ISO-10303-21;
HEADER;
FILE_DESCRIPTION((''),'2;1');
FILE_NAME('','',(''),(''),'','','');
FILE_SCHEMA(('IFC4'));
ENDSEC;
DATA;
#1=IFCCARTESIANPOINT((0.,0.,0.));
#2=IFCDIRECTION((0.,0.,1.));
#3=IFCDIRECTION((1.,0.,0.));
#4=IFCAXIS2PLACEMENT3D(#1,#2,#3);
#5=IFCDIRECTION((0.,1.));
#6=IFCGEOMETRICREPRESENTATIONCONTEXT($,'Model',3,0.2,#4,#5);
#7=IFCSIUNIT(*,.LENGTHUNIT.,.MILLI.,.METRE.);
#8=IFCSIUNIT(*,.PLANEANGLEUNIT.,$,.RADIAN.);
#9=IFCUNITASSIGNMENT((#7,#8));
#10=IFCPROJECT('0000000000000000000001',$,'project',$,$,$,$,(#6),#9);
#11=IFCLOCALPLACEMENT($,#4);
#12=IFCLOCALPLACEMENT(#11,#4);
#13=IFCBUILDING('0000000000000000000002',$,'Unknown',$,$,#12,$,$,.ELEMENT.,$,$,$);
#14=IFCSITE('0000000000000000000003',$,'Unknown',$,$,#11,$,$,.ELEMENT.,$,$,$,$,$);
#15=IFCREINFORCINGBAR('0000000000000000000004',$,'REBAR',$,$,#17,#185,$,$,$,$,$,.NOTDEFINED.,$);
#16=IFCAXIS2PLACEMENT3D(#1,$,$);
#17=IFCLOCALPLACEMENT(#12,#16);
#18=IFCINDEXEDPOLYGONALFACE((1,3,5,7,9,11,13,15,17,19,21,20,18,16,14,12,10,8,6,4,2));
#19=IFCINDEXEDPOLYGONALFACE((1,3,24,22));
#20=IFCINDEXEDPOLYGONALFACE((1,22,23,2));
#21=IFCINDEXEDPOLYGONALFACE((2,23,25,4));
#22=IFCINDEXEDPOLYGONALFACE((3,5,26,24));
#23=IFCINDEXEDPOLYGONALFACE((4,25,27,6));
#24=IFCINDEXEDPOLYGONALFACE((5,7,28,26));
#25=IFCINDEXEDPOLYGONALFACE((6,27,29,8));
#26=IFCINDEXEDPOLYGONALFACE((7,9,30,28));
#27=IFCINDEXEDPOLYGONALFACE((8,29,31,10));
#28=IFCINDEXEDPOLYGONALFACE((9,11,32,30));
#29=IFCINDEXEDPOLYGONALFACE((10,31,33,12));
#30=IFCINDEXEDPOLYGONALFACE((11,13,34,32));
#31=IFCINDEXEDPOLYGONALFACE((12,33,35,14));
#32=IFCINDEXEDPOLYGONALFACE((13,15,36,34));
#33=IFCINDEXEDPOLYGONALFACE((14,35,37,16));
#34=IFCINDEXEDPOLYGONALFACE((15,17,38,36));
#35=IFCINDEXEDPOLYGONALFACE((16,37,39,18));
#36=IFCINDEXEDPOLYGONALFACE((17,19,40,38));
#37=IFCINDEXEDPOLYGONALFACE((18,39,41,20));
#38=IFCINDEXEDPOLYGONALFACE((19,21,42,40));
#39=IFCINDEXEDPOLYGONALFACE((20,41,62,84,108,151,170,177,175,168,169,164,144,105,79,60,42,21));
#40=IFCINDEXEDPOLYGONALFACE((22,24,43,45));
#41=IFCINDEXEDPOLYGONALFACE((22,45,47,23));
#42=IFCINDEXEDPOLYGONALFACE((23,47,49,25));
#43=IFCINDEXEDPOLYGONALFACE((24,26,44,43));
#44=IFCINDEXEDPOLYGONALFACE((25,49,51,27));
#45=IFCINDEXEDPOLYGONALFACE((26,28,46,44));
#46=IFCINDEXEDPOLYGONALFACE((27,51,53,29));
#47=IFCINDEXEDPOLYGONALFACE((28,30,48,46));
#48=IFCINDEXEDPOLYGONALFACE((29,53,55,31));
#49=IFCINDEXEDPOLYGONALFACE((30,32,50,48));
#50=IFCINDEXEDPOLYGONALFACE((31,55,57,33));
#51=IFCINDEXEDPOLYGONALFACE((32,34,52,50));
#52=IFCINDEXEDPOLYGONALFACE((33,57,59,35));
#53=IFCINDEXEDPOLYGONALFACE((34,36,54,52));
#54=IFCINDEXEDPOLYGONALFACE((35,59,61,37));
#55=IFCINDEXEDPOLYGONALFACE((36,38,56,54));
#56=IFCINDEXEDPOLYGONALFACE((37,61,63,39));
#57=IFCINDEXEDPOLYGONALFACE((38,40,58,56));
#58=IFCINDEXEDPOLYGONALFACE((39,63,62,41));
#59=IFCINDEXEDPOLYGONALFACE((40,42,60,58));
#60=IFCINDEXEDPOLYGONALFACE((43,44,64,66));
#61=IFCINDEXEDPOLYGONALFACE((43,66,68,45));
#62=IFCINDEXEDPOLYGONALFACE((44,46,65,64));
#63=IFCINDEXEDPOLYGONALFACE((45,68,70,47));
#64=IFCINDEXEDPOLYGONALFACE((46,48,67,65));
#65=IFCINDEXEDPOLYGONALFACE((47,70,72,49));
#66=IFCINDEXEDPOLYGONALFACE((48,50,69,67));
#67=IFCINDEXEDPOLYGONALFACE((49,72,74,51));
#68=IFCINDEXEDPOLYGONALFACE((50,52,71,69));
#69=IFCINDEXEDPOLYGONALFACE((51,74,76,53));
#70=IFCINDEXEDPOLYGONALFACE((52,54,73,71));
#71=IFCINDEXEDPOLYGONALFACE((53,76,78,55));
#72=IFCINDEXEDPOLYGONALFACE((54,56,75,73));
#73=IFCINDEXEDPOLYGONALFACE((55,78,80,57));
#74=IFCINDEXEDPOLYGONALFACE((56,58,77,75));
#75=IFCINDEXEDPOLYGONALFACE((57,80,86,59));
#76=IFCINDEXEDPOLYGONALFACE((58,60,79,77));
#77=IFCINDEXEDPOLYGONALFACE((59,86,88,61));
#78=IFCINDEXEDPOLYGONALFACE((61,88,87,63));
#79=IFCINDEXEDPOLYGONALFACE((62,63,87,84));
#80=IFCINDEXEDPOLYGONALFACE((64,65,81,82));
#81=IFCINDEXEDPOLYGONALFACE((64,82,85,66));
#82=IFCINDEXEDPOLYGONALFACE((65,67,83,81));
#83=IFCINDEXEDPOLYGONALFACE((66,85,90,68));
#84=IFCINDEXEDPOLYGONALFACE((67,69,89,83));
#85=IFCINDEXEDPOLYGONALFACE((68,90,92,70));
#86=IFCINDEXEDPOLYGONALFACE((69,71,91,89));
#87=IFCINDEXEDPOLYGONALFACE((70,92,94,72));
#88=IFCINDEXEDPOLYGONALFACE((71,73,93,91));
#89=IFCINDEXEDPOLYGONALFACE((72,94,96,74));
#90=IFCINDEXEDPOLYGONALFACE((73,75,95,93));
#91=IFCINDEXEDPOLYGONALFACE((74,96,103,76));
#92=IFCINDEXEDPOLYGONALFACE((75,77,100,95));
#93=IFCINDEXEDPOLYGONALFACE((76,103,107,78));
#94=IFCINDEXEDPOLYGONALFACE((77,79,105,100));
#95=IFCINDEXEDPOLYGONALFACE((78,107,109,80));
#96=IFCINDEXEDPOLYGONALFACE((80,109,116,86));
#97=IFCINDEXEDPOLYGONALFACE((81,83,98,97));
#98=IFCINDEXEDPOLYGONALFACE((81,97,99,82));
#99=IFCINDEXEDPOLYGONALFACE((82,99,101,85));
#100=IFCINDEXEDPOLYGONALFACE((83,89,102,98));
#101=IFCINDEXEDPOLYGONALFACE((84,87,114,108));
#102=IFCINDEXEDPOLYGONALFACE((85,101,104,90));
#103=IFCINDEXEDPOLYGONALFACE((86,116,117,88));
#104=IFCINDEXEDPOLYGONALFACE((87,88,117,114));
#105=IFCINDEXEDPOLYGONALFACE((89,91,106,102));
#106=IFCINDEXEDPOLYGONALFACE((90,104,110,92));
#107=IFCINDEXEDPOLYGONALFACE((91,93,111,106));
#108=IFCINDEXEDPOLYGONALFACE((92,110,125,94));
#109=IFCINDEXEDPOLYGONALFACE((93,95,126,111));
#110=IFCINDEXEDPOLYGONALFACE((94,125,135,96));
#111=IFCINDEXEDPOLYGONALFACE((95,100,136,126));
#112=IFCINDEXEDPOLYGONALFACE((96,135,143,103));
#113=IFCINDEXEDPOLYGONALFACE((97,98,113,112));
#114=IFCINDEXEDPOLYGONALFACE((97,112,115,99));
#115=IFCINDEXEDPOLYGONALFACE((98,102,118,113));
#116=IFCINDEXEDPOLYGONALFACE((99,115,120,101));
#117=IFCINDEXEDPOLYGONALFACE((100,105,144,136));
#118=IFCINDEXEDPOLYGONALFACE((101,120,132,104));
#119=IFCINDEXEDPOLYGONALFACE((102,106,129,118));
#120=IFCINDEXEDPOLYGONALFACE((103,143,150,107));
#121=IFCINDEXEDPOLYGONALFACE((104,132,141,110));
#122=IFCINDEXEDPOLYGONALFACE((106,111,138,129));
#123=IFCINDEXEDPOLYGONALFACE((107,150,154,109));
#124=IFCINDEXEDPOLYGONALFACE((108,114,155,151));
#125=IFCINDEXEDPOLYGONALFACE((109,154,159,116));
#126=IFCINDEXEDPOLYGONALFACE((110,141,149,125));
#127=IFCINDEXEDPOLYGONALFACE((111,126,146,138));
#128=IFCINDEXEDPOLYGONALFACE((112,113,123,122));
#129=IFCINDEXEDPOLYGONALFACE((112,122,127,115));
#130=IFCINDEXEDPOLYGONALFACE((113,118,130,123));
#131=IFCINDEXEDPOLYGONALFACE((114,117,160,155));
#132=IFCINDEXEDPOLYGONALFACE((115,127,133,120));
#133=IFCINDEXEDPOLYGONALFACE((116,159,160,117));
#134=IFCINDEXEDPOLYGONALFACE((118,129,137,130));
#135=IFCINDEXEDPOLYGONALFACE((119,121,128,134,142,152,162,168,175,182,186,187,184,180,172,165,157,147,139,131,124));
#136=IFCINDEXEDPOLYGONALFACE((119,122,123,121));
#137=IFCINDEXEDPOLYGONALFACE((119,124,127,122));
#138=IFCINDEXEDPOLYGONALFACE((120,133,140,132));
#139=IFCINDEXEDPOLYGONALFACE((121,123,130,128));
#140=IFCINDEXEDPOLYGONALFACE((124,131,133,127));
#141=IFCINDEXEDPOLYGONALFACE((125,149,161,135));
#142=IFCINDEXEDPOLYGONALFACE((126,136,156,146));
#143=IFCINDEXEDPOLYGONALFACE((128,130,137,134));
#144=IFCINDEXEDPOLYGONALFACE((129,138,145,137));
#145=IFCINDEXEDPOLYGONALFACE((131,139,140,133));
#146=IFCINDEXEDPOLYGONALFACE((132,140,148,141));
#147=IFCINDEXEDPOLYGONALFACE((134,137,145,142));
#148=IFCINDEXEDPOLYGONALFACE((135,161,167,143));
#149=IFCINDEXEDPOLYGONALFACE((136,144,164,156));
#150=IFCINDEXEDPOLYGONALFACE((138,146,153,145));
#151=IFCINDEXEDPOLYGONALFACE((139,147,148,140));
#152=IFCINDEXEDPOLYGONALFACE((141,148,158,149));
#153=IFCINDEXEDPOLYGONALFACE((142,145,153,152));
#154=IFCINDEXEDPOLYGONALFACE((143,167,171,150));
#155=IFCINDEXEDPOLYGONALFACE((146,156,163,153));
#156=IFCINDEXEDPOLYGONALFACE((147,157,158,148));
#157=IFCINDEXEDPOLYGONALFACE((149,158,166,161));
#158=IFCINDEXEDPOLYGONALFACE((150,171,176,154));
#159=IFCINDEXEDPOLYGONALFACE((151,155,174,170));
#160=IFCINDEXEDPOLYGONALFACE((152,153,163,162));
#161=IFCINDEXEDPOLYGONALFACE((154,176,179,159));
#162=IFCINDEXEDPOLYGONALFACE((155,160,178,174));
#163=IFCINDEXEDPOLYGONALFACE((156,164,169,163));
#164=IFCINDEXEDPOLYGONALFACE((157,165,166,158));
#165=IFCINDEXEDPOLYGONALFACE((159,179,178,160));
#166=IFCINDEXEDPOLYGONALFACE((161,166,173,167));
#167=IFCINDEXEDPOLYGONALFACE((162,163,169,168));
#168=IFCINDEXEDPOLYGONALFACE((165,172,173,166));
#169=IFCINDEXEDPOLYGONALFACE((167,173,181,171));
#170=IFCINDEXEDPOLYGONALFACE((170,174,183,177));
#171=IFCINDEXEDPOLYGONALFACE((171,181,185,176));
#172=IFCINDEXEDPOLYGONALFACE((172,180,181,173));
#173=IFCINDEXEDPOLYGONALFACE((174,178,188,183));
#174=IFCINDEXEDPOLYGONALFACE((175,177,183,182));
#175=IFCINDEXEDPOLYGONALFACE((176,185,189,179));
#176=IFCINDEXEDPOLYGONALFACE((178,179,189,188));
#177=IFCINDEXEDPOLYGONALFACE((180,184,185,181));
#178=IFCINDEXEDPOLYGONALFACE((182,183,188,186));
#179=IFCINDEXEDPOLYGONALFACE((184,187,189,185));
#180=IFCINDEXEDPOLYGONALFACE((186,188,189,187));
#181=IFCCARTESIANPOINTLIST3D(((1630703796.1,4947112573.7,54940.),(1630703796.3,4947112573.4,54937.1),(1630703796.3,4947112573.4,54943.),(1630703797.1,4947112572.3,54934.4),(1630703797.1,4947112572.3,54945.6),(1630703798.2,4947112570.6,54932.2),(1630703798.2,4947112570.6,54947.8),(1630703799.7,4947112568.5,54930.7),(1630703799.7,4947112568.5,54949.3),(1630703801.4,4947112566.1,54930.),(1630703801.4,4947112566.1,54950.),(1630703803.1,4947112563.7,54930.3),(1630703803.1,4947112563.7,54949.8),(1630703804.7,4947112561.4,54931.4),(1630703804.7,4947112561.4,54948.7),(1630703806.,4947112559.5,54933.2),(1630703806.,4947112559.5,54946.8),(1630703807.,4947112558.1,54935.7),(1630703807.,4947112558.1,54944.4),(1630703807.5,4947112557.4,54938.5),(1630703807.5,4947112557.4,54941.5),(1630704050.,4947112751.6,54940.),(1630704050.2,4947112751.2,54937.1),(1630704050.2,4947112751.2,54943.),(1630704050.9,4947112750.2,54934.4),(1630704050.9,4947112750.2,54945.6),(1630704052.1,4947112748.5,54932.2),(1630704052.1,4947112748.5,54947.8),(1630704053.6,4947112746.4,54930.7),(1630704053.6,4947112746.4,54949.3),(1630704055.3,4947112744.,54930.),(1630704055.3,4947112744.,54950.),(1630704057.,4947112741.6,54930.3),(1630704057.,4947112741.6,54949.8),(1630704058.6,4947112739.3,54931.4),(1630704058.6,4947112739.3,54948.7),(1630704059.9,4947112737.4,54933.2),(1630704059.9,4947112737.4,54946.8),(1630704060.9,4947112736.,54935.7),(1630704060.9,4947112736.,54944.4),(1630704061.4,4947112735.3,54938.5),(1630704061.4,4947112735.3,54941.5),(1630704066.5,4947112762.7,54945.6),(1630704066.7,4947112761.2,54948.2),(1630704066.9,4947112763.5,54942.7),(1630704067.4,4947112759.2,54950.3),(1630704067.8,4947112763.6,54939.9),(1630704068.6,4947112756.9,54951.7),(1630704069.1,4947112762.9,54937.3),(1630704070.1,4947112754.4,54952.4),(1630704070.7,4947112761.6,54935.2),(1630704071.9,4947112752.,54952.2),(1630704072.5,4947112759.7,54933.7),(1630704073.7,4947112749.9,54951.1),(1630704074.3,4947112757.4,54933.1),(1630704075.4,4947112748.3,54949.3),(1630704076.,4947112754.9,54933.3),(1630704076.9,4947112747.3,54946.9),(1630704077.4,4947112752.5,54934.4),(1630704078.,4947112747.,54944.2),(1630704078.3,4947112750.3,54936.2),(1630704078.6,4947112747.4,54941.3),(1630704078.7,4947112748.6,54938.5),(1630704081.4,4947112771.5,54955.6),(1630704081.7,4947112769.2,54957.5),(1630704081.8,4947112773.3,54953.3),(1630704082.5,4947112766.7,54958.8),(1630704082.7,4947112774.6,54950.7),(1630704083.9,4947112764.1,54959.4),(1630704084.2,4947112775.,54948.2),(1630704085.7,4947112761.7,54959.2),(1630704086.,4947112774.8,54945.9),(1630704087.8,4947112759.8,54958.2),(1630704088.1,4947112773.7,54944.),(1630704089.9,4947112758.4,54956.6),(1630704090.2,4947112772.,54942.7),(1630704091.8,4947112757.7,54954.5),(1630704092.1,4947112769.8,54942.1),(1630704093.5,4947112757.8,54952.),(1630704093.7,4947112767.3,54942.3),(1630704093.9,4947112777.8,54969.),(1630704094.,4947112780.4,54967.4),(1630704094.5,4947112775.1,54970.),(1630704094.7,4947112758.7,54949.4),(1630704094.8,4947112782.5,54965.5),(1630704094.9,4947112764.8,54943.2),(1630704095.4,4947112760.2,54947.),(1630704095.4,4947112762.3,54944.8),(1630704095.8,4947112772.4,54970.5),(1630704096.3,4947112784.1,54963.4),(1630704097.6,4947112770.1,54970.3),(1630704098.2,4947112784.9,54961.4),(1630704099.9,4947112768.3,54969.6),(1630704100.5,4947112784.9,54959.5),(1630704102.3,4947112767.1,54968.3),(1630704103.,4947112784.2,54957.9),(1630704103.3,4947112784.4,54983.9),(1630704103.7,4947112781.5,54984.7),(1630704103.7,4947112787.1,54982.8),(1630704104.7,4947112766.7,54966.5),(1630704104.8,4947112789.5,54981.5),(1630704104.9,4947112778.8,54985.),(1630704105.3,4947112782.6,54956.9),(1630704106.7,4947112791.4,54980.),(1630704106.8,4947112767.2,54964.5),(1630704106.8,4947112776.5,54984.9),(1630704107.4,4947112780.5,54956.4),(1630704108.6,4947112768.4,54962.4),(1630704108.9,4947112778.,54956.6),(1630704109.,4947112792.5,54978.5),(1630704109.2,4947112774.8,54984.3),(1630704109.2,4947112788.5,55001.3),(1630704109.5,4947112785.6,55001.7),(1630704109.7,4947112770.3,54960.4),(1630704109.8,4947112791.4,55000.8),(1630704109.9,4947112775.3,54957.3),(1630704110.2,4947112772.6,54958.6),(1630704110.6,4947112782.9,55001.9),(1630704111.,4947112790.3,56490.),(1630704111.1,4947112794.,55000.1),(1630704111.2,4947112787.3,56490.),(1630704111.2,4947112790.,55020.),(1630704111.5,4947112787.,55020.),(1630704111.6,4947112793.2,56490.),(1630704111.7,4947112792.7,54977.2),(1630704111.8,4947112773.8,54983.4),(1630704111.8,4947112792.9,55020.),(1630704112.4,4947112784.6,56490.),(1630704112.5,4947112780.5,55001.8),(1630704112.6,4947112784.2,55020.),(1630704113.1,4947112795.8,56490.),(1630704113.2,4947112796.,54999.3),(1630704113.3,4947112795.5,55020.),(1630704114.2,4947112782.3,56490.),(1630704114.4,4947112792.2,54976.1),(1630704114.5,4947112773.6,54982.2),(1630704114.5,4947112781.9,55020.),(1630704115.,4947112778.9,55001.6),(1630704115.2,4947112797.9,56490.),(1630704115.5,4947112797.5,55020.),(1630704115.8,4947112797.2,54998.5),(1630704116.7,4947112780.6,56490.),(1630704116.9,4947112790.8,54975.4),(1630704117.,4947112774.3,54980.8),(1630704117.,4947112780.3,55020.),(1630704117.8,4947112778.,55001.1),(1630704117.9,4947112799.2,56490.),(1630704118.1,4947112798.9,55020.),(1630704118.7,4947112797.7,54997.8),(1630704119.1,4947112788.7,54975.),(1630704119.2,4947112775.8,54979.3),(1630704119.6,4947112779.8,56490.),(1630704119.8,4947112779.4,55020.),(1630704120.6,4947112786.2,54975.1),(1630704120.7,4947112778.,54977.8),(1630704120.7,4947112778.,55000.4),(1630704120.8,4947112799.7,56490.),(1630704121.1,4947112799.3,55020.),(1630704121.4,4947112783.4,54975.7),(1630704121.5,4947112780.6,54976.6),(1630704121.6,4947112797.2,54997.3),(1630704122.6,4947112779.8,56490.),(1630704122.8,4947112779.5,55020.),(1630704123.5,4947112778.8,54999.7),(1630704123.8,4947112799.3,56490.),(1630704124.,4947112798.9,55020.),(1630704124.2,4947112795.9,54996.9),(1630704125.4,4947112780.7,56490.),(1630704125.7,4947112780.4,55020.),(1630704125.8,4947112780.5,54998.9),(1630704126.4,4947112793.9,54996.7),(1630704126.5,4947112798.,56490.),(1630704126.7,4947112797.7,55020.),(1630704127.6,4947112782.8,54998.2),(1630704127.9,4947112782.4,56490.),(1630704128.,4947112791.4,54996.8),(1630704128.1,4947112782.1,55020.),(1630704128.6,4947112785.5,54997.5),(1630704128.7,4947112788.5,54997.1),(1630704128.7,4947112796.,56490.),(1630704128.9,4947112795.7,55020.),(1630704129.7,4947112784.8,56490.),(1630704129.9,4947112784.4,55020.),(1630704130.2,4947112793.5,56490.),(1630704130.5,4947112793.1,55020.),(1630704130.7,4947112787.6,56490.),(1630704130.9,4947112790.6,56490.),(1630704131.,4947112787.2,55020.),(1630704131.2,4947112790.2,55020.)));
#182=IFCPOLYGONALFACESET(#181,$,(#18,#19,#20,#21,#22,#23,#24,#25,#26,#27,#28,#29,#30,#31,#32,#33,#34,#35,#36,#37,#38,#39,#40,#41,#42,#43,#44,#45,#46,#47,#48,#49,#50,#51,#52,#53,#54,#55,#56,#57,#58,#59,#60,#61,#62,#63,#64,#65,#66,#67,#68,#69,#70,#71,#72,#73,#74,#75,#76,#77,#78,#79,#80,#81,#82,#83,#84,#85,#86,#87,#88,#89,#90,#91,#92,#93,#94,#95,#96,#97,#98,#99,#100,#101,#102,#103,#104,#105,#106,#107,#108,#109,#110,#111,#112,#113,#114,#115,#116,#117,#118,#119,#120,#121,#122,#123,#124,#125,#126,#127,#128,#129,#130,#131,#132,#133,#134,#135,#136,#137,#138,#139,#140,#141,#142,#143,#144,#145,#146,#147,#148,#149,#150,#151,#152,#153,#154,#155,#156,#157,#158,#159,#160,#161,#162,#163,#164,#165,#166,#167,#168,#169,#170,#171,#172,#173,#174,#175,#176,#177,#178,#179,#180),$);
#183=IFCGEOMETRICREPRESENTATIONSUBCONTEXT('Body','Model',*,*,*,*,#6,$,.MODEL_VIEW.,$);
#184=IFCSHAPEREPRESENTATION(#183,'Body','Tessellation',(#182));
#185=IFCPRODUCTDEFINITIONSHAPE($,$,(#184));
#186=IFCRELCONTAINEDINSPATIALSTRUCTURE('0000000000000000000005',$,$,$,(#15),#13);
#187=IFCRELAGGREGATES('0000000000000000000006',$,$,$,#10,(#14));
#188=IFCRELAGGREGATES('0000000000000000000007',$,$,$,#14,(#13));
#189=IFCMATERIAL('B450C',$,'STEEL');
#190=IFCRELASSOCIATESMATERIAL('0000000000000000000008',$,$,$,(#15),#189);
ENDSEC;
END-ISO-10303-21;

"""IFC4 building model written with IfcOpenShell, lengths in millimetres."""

from ifc_helpers import new_model, entity, si_unit, direction, frame, origin_with_axes, place, context, subcontext, project, spatial, material, element, save


model = new_model("IFC4")

# Units and contexts
model_context = context("Model", 3, precision=0.2, world=origin_with_axes(), true_north=direction((0.0, 1.0)))
body_context = subcontext(model_context, "Body", "Model", "MODEL_VIEW")
ifc_project = project(units=[si_unit("LENGTHUNIT", "METRE", prefix="MILLI"), si_unit("PLANEANGLEUNIT", "RADIAN")], contexts=[model_context])

# Site, building
site_placement = place(None, origin_with_axes())
site = spatial("IfcSite", under=ifc_project, at=site_placement, Name="Unknown", CompositionType="ELEMENT")
building_placement = place(site_placement, origin_with_axes())
building = spatial("IfcBuilding", under=site, at=building_placement, Name="Unknown", CompositionType="ELEMENT")

# Reinforcing bar
ifc_material = material(Name="B450C", Category="STEEL")
reinforcing_bar_1_placement = place(building_placement, frame((1630704133.5, 4947112858.9, 54890.0), z_axis=(0.573819, -0.818982, 0.0), x_axis=(0.0, 0.0, 1.0)))
element("IfcReinforcingBar", 1, at=reinforcing_bar_1_placement, inside=building, material=ifc_material, Name="REBAR", PredefinedType="NOTDEFINED", context=body_context, shape_type="AdvancedSweptSolid", body=[
    entity("IfcSweptDiskSolid", entity("IfcIndexedPolyCurve", entity("IfcCartesianPointList3D", [[50.0, 440.0, 50.0], [50.0, 130.0, 50.0], [73.4, 73.4, 50.0], [130.0, 50.0, 50.0], [1600.0, 50.0, 49.5]]), [entity("IfcLineIndex", [1, 2]), entity("IfcArcIndex", [2, 3, 4]), entity("IfcLineIndex", [4, 5])]), 10.0),
])

save(model, "model.ifc")
